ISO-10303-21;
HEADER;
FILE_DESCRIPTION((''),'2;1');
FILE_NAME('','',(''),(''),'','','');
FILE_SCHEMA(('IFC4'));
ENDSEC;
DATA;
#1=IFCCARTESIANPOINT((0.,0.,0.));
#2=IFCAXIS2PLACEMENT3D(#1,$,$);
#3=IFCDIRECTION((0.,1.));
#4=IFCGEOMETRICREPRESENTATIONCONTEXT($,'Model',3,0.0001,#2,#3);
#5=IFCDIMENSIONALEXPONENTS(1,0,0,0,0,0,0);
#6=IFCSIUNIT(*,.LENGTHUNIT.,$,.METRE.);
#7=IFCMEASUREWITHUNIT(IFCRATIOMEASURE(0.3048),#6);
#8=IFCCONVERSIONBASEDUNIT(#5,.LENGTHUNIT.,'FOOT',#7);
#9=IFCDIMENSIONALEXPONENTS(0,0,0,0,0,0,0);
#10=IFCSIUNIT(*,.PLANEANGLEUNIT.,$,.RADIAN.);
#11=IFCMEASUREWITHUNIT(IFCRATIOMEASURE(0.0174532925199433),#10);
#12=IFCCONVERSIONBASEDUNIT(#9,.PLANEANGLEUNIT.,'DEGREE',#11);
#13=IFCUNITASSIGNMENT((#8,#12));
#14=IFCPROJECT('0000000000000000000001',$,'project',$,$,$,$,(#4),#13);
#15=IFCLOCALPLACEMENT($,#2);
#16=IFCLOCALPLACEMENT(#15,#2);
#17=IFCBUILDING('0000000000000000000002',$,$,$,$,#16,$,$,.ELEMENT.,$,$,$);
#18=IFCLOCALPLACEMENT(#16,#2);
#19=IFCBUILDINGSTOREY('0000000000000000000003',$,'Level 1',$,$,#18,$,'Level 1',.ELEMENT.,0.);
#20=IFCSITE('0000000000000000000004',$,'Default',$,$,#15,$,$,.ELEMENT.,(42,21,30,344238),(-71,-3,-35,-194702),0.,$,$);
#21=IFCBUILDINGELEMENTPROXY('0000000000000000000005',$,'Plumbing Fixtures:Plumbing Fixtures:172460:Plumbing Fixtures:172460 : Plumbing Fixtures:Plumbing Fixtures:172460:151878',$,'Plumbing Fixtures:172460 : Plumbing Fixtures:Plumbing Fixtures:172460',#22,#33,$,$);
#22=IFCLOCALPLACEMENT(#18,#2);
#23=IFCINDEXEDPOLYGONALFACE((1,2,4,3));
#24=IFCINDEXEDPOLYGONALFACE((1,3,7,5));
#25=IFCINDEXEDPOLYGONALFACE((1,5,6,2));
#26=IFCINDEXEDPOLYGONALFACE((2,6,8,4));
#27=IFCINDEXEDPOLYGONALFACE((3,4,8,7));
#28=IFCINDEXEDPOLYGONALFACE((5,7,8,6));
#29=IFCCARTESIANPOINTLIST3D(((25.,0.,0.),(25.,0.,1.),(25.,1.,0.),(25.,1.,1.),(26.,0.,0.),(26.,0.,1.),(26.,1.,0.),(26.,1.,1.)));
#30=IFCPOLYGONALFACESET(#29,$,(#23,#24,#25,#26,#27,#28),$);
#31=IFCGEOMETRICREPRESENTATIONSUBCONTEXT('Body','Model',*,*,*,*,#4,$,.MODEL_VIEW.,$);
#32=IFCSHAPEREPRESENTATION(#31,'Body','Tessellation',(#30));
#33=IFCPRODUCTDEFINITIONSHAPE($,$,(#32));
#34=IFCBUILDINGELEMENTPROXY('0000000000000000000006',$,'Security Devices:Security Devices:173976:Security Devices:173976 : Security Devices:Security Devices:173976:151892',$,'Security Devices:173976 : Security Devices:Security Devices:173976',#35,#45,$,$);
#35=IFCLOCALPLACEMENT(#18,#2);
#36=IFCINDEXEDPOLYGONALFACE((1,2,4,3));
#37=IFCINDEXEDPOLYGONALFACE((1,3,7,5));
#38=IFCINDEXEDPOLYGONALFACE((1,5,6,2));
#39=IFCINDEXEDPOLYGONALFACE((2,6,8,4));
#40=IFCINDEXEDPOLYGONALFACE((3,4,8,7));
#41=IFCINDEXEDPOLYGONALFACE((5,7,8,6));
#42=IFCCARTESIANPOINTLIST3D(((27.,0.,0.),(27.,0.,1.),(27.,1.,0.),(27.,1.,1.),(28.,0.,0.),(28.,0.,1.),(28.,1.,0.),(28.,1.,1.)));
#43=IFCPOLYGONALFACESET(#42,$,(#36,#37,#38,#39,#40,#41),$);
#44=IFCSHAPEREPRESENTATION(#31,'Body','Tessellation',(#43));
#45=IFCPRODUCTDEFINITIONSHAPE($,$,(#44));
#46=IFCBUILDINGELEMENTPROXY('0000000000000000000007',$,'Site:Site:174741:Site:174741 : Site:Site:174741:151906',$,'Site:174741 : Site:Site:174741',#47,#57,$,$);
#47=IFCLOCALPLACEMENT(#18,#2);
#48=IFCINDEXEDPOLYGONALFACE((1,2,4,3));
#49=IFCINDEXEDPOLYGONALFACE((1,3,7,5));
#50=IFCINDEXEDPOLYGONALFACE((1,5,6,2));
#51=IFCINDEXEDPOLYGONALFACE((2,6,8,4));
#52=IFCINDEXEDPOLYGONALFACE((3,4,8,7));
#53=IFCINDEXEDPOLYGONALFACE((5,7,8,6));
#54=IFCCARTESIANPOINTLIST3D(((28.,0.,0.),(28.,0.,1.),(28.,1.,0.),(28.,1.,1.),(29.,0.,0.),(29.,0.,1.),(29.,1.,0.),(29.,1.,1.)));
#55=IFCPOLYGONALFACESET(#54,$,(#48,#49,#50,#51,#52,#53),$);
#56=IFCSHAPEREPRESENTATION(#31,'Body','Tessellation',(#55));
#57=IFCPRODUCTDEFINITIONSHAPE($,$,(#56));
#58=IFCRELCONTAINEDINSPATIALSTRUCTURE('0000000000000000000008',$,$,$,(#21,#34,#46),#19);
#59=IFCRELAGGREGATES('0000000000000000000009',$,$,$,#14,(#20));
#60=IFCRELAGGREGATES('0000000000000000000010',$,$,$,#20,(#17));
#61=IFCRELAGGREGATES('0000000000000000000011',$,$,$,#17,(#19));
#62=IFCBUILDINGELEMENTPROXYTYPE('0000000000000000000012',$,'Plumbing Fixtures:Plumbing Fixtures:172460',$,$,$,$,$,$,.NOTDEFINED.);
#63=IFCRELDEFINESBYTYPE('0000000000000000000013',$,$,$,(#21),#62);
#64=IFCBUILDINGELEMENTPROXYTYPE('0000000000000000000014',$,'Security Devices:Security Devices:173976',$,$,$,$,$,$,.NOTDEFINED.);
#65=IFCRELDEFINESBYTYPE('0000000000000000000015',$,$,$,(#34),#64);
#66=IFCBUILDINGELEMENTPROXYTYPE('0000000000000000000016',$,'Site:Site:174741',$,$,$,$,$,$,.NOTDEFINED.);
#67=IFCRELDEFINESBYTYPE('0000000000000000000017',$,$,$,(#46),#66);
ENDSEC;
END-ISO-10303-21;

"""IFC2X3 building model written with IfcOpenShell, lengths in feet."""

from ifc_helpers import new_model, entity, si_unit, converted_unit, direction, frame, origin, origin_2d_with_axis, place, context, subcontext, project, spatial, rectangle, extrude, source, transform, mapped, type_object, type_shapes, element, save


model = new_model("IFC2X3")

# Units and contexts
model_context = context("Model", 3, precision=0.0001, world=origin(), true_north=direction((0.0, 1.0)))
body_context = subcontext(model_context, "Body", "Model", "MODEL_VIEW")
ifc_project = project(units=[converted_unit("LENGTHUNIT", "FOOT", entity("IfcRatioMeasure", 0.3048), si_unit("LENGTHUNIT", "METRE"), dimensions=[1, 0, 0, 0, 0, 0, 0]), converted_unit("PLANEANGLEUNIT", "DEGREE", entity("IfcRatioMeasure", 0.0174532925199433), si_unit("PLANEANGLEUNIT", "RADIAN"), dimensions=[0, 0, 0, 0, 0, 0, 0])], contexts=[model_context])

# Site, building, storey
site_placement = place(None, origin())
site = spatial("IfcSite", under=ifc_project, at=site_placement, Name="Default", CompositionType="ELEMENT", RefLatitude=(42, 21, 30, 344238), RefLongitude=(-71, -3, -35, -194702), RefElevation=0.0)
building_placement = place(site_placement, origin())
building = spatial("IfcBuilding", under=site, at=building_placement, CompositionType="ELEMENT")
storey_placement = place(building_placement, origin())
storey = spatial("IfcBuildingStorey", under=building, at=storey_placement, Name="Level 1", LongName="Level 1", CompositionType="ELEMENT", Elevation=0.0)

# Building element proxies
building_element_proxy_type_1 = type_object("IfcBuildingElementProxyType", Name="Plumbing Fixtures:Plumbing Fixtures:172460", PredefinedType="NOTDEFINED")
shared_shape_1 = source(origin(), body_context, "Body", "SweptSolid", [
    extrude(rectangle(XDim=1.0, YDim=1.0, at=origin_2d_with_axis()), frame((25.5, 0.5, 0.0), z_axis=(0.0, 0.0, 1.0), x_axis=(-1.0, 0.0, 0.0)), (0.0, 0.0, 1.0), 1.0),
])
type_shapes(building_element_proxy_type_1, [shared_shape_1])
proxy_1_placement = place(storey_placement, origin())
element("IfcBuildingElementProxy", 1, at=proxy_1_placement, inside=storey, type_object=building_element_proxy_type_1, Name="Plumbing Fixtures:Plumbing Fixtures:172460:Plumbing Fixtures:172460 : Plumbing Fixtures:Plumbing Fixtures:172460:151878", ObjectType="Plumbing Fixtures:172460 : Plumbing Fixtures:Plumbing Fixtures:172460", context=body_context, shape_type="MappedRepresentation", body=[
    mapped(shared_shape_1, transform((0.0, 0.0, 0.0), scale=1.0)),
])
building_element_proxy_type_2 = type_object("IfcBuildingElementProxyType", Name="Security Devices:Security Devices:173976", PredefinedType="NOTDEFINED")
shared_shape_2 = source(origin(), body_context, "Body", "SweptSolid", [
    extrude(rectangle(XDim=1.0, YDim=1.0, at=origin_2d_with_axis()), frame((27.5, 0.5, 0.0), z_axis=(0.0, 0.0, 1.0), x_axis=(-1.0, 0.0, 0.0)), (0.0, 0.0, 1.0), 1.0),
])
type_shapes(building_element_proxy_type_2, [shared_shape_2])
proxy_2_placement = place(storey_placement, origin())
element("IfcBuildingElementProxy", 2, at=proxy_2_placement, inside=storey, type_object=building_element_proxy_type_2, Name="Security Devices:Security Devices:173976:Security Devices:173976 : Security Devices:Security Devices:173976:151892", ObjectType="Security Devices:173976 : Security Devices:Security Devices:173976", context=body_context, shape_type="MappedRepresentation", body=[
    mapped(shared_shape_2, transform((0.0, 0.0, 0.0), scale=1.0)),
])
building_element_proxy_type_3 = type_object("IfcBuildingElementProxyType", Name="Site:Site:174741", PredefinedType="NOTDEFINED")
shared_shape_3 = source(origin(), body_context, "Body", "SweptSolid", [
    extrude(rectangle(XDim=1.0, YDim=1.0, at=origin_2d_with_axis()), frame((28.5, 0.5, 0.0), z_axis=(0.0, 0.0, 1.0), x_axis=(-1.0, 0.0, 0.0)), (0.0, 0.0, 1.0), 1.0),
])
type_shapes(building_element_proxy_type_3, [shared_shape_3])
proxy_3_placement = place(storey_placement, origin())
element("IfcBuildingElementProxy", 3, at=proxy_3_placement, inside=storey, type_object=building_element_proxy_type_3, Name="Site:Site:174741:Site:174741 : Site:Site:174741:151906", ObjectType="Site:174741 : Site:Site:174741", context=body_context, shape_type="MappedRepresentation", body=[
    mapped(shared_shape_3, transform((0.0, 0.0, 0.0), scale=1.0)),
])

save(model, "model.ifc")
